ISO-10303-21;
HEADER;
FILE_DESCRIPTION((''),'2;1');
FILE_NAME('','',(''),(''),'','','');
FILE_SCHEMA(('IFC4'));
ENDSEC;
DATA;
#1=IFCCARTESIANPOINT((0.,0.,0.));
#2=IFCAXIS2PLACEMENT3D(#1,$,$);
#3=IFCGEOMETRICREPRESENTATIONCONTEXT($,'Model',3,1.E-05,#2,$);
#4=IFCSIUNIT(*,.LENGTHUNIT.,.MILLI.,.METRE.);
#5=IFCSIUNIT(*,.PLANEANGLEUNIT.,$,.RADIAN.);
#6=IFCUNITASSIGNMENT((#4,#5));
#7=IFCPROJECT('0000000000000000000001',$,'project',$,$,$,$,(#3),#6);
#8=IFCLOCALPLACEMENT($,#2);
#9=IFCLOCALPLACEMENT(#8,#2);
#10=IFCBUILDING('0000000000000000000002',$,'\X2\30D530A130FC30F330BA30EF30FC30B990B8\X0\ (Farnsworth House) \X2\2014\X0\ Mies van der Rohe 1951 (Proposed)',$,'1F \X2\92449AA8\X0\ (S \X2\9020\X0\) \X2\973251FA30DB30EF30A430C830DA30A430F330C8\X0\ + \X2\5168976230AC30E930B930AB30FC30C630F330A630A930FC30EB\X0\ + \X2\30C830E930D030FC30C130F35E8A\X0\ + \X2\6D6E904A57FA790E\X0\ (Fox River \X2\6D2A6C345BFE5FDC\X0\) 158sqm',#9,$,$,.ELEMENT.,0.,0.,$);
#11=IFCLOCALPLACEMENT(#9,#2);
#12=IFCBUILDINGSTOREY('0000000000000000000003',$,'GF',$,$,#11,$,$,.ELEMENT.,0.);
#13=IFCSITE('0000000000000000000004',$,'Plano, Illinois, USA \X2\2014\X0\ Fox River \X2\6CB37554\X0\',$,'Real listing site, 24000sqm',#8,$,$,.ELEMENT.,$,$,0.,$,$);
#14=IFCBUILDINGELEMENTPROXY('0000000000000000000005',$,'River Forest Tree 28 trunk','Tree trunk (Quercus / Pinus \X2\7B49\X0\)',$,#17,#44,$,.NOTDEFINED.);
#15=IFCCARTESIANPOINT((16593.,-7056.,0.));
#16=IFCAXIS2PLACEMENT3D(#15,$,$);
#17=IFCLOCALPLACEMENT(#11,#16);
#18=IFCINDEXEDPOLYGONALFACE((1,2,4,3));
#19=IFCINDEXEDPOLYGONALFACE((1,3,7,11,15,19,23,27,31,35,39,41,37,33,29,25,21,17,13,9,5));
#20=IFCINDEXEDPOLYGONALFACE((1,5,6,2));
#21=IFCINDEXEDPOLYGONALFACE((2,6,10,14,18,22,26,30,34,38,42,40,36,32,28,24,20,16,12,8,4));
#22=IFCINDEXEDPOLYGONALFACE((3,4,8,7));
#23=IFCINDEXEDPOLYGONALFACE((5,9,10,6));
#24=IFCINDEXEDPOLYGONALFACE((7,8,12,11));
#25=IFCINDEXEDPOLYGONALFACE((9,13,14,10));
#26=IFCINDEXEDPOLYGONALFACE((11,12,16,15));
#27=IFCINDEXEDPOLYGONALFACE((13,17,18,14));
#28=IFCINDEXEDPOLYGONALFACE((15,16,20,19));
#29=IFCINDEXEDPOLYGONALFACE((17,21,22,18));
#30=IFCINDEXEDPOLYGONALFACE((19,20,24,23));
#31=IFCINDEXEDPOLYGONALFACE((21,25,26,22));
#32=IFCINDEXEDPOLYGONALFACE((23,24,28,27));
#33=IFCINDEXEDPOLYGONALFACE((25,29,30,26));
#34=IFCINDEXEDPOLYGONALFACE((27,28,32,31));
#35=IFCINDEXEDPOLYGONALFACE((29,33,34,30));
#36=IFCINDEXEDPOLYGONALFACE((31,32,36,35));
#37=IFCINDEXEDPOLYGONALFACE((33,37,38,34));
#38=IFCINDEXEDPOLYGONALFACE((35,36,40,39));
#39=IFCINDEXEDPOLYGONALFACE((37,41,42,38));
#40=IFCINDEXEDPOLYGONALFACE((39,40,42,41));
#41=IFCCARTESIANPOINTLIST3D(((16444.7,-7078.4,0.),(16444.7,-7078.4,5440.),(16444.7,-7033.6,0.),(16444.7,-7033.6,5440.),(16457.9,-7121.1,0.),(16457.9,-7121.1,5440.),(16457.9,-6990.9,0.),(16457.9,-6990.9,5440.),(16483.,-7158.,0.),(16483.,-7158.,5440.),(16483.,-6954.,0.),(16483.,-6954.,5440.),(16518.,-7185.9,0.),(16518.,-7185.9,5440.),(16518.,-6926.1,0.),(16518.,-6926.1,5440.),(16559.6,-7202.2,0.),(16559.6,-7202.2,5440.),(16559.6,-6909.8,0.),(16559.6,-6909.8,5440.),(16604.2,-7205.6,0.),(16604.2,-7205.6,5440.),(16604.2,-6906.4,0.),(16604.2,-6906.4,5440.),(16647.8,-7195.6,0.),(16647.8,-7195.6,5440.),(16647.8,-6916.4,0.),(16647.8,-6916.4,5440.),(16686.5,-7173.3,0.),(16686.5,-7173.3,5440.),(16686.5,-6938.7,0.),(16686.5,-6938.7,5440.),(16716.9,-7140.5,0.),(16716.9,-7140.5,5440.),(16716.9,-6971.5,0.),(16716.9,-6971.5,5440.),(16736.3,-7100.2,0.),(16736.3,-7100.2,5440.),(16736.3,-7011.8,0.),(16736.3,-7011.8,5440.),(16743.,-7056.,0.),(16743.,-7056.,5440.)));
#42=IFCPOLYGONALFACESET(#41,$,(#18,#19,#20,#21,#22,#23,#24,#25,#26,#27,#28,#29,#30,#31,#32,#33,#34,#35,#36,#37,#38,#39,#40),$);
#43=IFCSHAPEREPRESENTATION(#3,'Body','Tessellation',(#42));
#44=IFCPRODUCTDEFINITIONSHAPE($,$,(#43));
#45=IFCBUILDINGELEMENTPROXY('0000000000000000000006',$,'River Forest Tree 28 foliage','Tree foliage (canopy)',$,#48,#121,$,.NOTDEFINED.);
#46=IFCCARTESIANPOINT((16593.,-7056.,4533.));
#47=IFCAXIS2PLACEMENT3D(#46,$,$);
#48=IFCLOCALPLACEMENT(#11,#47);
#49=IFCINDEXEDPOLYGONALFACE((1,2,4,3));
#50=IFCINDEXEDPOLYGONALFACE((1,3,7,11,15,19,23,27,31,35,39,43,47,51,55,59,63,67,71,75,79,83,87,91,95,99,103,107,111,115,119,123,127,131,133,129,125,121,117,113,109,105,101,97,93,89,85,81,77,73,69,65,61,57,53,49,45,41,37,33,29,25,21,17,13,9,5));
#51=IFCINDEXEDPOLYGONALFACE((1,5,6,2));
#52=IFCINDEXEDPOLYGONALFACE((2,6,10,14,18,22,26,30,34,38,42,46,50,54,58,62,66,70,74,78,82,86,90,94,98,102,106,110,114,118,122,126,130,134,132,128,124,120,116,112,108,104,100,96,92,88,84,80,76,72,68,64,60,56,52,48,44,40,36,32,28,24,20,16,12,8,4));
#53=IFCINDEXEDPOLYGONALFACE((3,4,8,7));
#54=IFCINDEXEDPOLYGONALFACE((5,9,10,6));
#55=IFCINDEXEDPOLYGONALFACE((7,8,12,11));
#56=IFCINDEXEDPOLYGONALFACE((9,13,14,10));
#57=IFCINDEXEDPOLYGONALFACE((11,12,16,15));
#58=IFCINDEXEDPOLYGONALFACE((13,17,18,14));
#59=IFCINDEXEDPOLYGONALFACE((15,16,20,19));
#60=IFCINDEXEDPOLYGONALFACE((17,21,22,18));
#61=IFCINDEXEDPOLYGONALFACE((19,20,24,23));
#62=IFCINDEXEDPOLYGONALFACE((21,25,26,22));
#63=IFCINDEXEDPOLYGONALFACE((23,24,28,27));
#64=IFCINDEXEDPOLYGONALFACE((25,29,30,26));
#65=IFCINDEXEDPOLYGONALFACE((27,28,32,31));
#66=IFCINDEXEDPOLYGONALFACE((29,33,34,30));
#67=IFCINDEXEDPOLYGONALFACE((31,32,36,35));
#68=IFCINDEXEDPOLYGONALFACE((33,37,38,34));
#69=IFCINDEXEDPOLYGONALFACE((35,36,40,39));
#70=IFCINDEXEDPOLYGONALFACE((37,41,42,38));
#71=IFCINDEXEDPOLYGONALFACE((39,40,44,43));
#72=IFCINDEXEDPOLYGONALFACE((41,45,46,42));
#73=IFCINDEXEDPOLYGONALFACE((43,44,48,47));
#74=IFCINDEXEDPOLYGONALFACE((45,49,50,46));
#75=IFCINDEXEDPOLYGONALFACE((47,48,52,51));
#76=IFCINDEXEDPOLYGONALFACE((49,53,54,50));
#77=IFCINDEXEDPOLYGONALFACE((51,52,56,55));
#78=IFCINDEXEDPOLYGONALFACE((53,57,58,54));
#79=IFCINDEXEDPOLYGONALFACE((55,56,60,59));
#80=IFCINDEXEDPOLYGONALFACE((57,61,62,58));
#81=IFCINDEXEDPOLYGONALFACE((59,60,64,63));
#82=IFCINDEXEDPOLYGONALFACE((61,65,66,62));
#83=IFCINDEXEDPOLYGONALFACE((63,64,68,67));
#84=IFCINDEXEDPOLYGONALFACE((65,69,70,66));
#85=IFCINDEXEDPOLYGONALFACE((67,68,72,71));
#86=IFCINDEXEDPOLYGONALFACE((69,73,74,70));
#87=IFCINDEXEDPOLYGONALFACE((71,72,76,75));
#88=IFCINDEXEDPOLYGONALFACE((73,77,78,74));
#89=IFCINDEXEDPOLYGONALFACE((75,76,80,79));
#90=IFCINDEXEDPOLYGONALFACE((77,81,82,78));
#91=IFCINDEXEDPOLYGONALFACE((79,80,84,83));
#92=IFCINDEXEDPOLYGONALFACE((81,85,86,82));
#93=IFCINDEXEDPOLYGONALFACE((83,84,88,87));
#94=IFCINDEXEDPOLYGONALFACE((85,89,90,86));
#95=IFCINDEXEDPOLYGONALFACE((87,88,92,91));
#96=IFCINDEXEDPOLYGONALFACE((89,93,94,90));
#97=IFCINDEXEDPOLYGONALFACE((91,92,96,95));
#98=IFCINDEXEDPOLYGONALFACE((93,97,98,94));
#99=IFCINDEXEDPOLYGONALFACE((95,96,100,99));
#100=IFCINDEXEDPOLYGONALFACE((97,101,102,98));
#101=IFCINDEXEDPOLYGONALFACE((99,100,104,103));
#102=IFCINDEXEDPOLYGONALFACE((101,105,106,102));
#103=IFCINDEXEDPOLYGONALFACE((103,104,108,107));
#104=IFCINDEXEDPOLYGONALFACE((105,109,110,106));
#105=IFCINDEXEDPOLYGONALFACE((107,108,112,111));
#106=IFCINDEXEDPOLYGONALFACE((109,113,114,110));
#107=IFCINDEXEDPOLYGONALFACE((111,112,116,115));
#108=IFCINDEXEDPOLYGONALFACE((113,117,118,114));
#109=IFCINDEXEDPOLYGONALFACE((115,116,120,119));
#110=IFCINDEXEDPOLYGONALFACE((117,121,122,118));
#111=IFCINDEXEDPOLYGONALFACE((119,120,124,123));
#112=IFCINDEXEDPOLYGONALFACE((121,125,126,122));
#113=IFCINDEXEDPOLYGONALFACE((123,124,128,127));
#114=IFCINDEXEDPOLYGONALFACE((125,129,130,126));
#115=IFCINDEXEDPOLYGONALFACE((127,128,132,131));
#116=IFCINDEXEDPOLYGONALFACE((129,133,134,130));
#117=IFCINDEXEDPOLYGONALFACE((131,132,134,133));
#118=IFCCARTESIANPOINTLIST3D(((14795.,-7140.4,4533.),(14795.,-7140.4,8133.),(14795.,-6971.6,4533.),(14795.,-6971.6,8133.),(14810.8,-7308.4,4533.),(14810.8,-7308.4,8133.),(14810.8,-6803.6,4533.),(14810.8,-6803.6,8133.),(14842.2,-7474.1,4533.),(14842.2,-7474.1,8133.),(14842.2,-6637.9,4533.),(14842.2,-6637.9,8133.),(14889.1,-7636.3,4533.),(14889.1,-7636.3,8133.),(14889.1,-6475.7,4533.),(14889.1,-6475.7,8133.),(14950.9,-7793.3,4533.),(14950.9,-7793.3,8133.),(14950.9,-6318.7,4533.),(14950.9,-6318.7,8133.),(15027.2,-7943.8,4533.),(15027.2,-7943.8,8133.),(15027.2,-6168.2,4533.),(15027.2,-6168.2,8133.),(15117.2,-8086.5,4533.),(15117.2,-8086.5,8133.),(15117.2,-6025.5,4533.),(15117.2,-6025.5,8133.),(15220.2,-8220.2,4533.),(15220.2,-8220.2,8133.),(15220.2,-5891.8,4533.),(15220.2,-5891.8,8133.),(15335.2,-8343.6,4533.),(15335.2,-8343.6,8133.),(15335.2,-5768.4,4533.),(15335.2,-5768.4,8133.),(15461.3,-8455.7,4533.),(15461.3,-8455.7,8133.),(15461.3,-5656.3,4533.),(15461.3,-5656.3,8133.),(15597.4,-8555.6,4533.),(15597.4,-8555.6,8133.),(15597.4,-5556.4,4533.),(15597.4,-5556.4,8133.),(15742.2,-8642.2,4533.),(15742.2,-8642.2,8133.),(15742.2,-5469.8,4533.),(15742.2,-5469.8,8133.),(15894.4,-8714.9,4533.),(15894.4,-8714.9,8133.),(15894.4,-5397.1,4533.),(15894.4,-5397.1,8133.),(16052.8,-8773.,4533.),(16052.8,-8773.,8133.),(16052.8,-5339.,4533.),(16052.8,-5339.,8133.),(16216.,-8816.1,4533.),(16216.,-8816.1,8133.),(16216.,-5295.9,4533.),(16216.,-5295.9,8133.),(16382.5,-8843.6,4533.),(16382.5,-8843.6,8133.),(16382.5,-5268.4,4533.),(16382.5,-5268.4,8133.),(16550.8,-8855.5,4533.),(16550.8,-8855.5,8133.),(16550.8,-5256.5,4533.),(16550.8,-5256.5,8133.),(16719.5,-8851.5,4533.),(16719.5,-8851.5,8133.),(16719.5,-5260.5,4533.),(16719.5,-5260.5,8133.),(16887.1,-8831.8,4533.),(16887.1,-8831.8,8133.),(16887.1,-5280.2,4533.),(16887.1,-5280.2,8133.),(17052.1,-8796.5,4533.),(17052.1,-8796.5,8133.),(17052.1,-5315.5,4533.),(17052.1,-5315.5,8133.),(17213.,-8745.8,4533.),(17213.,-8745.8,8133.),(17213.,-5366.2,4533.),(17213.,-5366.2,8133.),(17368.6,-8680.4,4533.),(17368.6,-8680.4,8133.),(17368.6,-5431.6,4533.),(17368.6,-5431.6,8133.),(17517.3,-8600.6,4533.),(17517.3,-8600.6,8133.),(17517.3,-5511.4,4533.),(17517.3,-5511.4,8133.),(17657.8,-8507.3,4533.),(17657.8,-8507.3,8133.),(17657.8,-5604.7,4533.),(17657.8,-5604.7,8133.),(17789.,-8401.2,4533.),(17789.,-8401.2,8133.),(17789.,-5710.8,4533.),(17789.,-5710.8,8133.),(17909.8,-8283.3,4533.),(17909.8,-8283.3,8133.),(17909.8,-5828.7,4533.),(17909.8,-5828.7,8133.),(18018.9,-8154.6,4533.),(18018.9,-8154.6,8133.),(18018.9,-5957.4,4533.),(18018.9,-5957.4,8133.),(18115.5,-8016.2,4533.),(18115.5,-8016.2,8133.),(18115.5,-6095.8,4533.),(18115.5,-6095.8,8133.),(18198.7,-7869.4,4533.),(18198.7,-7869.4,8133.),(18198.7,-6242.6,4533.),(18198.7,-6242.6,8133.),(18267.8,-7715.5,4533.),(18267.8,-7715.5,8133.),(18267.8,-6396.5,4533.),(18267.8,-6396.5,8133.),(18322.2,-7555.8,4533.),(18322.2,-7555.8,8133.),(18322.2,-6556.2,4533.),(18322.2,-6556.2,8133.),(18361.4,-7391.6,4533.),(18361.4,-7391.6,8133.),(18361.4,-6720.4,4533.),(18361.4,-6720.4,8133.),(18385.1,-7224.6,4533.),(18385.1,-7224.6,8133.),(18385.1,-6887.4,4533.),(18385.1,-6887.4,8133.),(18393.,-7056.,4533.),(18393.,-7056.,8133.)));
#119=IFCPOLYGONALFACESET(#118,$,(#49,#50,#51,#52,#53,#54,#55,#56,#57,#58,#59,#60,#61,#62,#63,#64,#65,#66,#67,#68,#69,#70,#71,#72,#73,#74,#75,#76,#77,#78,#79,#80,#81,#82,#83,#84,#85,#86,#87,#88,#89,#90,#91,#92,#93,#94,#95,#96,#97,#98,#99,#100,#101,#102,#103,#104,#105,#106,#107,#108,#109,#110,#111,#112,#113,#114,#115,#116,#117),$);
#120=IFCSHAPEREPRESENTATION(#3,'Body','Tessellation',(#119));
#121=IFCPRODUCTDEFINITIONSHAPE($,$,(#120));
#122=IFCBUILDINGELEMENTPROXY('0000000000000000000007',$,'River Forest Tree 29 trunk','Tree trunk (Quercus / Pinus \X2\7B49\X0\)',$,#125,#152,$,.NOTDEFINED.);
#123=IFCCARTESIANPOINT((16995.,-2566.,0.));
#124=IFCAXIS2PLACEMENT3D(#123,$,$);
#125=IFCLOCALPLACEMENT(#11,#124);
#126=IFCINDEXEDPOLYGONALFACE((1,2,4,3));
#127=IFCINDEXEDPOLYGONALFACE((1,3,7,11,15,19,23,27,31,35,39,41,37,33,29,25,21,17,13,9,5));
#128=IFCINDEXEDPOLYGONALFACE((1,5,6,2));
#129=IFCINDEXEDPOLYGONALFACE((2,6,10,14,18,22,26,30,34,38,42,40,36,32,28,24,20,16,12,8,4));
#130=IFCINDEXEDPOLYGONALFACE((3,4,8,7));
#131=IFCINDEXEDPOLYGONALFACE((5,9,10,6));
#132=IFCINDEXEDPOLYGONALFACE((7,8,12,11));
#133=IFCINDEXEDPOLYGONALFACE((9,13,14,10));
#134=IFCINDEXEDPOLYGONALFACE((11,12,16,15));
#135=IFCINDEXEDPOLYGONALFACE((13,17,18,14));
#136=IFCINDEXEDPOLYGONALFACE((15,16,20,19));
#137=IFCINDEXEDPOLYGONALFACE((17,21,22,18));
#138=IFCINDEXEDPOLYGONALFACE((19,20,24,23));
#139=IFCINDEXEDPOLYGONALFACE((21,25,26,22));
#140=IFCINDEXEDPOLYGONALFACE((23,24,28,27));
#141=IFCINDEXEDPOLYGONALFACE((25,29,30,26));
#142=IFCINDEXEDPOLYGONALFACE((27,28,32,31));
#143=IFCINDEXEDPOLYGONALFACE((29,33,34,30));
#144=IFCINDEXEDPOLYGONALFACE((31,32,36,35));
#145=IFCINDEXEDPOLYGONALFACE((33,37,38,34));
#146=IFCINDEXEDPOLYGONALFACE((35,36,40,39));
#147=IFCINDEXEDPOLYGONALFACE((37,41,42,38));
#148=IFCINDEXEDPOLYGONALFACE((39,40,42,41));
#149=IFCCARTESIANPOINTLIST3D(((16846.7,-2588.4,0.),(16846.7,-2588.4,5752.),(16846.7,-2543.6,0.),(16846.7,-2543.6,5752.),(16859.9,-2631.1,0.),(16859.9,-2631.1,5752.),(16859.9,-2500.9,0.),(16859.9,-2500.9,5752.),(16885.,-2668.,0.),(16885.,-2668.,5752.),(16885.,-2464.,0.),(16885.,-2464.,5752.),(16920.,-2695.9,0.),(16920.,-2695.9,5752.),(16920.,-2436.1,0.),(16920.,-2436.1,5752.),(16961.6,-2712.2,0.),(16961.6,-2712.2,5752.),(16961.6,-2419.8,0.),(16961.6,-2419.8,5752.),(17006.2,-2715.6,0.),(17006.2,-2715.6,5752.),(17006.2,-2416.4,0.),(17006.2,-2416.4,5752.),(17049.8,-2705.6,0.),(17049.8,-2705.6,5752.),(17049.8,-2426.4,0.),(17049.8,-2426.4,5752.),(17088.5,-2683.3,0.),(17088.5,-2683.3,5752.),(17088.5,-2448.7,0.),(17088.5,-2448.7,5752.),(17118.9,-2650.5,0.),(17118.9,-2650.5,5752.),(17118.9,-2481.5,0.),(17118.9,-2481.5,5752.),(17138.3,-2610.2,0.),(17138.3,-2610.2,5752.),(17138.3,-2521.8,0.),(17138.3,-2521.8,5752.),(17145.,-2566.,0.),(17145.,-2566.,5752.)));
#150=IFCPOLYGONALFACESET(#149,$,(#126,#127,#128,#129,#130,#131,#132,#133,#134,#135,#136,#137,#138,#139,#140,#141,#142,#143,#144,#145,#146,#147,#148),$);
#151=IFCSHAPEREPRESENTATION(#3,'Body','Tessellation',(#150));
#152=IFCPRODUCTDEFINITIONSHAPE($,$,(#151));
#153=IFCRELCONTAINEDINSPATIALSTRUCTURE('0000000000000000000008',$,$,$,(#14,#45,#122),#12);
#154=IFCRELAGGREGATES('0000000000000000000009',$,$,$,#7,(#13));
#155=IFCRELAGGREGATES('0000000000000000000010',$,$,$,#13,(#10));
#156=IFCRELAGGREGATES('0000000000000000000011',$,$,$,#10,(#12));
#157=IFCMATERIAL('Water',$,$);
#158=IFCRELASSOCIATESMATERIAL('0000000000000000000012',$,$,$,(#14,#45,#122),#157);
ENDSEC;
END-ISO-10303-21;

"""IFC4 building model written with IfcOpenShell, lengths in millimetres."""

from ifc_helpers import new_model, si_unit, frame, origin, origin_2d, place, context, project, spatial, circle, extrude, material, element, save


model = new_model("IFC4")

# Units and contexts
model_context = context("Model", 3, precision=1e-05, world=origin())
ifc_project = project(units=[si_unit("LENGTHUNIT", "METRE", prefix="MILLI"), si_unit("PLANEANGLEUNIT", "RADIAN")], contexts=[model_context])

# Site, building, storey
site_placement = place(None, origin())
site = spatial("IfcSite", under=ifc_project, at=site_placement, Name="Plano, Illinois, USA — Fox River 河畔", ObjectType="Real listing site, 24000sqm", CompositionType="ELEMENT", RefElevation=0.0)
building_placement = place(site_placement, origin())
building = spatial("IfcBuilding", under=site, at=building_placement, Name="ファーンズワース邸 (Farnsworth House) — Mies van der Rohe 1951 (Proposed)", ObjectType="1F 鉄骨 (S 造) 露出ホワイトペイント + 全面ガラスカーテンウォール + トラバーチン床 + 浮遊基礎 (Fox River 洪水対応) 158sqm", CompositionType="ELEMENT", ElevationOfRefHeight=0.0, ElevationOfTerrain=0.0)
storey_placement = place(building_placement, origin())
storey = spatial("IfcBuildingStorey", under=building, at=storey_placement, Name="GF", CompositionType="ELEMENT", Elevation=0.0)

# Building element proxies
ifc_material_1 = material(Name="Water")
proxy_1_placement = place(storey_placement, frame((16593.0, -7056.0, 0.0)))
element("IfcBuildingElementProxy", 1, at=proxy_1_placement, inside=storey, material=ifc_material_1, Name="River Forest Tree 28 trunk", Description="Tree trunk (Quercus / Pinus 等)", PredefinedType="NOTDEFINED", context=model_context, shape_type="SweptSolid", body=[
    extrude(circle(Radius=150.0, at=origin_2d()), frame((16593.0, -7056.0, 0.0)), (0.0, 0.0, 1.0), 5440.0),
])
proxy_2_placement = place(storey_placement, frame((16593.0, -7056.0, 4533.0)))
element("IfcBuildingElementProxy", 2, at=proxy_2_placement, inside=storey, material=ifc_material_1, Name="River Forest Tree 28 foliage", Description="Tree foliage (canopy)", PredefinedType="NOTDEFINED", context=model_context, shape_type="SweptSolid", body=[
    extrude(circle(Radius=1800.0, at=origin_2d()), frame((16593.0, -7056.0, 4533.0)), (0.0, 0.0, 1.0), 3600.0),
])
proxy_3_placement = place(storey_placement, frame((16995.0, -2566.0, 0.0)))
element("IfcBuildingElementProxy", 3, at=proxy_3_placement, inside=storey, material=ifc_material_1, Name="River Forest Tree 29 trunk", Description="Tree trunk (Quercus / Pinus 等)", PredefinedType="NOTDEFINED", context=model_context, shape_type="SweptSolid", body=[
    extrude(circle(Radius=150.0, at=origin_2d()), frame((16995.0, -2566.0, 0.0)), (0.0, 0.0, 1.0), 5752.0),
])

save(model, "model.ifc")
